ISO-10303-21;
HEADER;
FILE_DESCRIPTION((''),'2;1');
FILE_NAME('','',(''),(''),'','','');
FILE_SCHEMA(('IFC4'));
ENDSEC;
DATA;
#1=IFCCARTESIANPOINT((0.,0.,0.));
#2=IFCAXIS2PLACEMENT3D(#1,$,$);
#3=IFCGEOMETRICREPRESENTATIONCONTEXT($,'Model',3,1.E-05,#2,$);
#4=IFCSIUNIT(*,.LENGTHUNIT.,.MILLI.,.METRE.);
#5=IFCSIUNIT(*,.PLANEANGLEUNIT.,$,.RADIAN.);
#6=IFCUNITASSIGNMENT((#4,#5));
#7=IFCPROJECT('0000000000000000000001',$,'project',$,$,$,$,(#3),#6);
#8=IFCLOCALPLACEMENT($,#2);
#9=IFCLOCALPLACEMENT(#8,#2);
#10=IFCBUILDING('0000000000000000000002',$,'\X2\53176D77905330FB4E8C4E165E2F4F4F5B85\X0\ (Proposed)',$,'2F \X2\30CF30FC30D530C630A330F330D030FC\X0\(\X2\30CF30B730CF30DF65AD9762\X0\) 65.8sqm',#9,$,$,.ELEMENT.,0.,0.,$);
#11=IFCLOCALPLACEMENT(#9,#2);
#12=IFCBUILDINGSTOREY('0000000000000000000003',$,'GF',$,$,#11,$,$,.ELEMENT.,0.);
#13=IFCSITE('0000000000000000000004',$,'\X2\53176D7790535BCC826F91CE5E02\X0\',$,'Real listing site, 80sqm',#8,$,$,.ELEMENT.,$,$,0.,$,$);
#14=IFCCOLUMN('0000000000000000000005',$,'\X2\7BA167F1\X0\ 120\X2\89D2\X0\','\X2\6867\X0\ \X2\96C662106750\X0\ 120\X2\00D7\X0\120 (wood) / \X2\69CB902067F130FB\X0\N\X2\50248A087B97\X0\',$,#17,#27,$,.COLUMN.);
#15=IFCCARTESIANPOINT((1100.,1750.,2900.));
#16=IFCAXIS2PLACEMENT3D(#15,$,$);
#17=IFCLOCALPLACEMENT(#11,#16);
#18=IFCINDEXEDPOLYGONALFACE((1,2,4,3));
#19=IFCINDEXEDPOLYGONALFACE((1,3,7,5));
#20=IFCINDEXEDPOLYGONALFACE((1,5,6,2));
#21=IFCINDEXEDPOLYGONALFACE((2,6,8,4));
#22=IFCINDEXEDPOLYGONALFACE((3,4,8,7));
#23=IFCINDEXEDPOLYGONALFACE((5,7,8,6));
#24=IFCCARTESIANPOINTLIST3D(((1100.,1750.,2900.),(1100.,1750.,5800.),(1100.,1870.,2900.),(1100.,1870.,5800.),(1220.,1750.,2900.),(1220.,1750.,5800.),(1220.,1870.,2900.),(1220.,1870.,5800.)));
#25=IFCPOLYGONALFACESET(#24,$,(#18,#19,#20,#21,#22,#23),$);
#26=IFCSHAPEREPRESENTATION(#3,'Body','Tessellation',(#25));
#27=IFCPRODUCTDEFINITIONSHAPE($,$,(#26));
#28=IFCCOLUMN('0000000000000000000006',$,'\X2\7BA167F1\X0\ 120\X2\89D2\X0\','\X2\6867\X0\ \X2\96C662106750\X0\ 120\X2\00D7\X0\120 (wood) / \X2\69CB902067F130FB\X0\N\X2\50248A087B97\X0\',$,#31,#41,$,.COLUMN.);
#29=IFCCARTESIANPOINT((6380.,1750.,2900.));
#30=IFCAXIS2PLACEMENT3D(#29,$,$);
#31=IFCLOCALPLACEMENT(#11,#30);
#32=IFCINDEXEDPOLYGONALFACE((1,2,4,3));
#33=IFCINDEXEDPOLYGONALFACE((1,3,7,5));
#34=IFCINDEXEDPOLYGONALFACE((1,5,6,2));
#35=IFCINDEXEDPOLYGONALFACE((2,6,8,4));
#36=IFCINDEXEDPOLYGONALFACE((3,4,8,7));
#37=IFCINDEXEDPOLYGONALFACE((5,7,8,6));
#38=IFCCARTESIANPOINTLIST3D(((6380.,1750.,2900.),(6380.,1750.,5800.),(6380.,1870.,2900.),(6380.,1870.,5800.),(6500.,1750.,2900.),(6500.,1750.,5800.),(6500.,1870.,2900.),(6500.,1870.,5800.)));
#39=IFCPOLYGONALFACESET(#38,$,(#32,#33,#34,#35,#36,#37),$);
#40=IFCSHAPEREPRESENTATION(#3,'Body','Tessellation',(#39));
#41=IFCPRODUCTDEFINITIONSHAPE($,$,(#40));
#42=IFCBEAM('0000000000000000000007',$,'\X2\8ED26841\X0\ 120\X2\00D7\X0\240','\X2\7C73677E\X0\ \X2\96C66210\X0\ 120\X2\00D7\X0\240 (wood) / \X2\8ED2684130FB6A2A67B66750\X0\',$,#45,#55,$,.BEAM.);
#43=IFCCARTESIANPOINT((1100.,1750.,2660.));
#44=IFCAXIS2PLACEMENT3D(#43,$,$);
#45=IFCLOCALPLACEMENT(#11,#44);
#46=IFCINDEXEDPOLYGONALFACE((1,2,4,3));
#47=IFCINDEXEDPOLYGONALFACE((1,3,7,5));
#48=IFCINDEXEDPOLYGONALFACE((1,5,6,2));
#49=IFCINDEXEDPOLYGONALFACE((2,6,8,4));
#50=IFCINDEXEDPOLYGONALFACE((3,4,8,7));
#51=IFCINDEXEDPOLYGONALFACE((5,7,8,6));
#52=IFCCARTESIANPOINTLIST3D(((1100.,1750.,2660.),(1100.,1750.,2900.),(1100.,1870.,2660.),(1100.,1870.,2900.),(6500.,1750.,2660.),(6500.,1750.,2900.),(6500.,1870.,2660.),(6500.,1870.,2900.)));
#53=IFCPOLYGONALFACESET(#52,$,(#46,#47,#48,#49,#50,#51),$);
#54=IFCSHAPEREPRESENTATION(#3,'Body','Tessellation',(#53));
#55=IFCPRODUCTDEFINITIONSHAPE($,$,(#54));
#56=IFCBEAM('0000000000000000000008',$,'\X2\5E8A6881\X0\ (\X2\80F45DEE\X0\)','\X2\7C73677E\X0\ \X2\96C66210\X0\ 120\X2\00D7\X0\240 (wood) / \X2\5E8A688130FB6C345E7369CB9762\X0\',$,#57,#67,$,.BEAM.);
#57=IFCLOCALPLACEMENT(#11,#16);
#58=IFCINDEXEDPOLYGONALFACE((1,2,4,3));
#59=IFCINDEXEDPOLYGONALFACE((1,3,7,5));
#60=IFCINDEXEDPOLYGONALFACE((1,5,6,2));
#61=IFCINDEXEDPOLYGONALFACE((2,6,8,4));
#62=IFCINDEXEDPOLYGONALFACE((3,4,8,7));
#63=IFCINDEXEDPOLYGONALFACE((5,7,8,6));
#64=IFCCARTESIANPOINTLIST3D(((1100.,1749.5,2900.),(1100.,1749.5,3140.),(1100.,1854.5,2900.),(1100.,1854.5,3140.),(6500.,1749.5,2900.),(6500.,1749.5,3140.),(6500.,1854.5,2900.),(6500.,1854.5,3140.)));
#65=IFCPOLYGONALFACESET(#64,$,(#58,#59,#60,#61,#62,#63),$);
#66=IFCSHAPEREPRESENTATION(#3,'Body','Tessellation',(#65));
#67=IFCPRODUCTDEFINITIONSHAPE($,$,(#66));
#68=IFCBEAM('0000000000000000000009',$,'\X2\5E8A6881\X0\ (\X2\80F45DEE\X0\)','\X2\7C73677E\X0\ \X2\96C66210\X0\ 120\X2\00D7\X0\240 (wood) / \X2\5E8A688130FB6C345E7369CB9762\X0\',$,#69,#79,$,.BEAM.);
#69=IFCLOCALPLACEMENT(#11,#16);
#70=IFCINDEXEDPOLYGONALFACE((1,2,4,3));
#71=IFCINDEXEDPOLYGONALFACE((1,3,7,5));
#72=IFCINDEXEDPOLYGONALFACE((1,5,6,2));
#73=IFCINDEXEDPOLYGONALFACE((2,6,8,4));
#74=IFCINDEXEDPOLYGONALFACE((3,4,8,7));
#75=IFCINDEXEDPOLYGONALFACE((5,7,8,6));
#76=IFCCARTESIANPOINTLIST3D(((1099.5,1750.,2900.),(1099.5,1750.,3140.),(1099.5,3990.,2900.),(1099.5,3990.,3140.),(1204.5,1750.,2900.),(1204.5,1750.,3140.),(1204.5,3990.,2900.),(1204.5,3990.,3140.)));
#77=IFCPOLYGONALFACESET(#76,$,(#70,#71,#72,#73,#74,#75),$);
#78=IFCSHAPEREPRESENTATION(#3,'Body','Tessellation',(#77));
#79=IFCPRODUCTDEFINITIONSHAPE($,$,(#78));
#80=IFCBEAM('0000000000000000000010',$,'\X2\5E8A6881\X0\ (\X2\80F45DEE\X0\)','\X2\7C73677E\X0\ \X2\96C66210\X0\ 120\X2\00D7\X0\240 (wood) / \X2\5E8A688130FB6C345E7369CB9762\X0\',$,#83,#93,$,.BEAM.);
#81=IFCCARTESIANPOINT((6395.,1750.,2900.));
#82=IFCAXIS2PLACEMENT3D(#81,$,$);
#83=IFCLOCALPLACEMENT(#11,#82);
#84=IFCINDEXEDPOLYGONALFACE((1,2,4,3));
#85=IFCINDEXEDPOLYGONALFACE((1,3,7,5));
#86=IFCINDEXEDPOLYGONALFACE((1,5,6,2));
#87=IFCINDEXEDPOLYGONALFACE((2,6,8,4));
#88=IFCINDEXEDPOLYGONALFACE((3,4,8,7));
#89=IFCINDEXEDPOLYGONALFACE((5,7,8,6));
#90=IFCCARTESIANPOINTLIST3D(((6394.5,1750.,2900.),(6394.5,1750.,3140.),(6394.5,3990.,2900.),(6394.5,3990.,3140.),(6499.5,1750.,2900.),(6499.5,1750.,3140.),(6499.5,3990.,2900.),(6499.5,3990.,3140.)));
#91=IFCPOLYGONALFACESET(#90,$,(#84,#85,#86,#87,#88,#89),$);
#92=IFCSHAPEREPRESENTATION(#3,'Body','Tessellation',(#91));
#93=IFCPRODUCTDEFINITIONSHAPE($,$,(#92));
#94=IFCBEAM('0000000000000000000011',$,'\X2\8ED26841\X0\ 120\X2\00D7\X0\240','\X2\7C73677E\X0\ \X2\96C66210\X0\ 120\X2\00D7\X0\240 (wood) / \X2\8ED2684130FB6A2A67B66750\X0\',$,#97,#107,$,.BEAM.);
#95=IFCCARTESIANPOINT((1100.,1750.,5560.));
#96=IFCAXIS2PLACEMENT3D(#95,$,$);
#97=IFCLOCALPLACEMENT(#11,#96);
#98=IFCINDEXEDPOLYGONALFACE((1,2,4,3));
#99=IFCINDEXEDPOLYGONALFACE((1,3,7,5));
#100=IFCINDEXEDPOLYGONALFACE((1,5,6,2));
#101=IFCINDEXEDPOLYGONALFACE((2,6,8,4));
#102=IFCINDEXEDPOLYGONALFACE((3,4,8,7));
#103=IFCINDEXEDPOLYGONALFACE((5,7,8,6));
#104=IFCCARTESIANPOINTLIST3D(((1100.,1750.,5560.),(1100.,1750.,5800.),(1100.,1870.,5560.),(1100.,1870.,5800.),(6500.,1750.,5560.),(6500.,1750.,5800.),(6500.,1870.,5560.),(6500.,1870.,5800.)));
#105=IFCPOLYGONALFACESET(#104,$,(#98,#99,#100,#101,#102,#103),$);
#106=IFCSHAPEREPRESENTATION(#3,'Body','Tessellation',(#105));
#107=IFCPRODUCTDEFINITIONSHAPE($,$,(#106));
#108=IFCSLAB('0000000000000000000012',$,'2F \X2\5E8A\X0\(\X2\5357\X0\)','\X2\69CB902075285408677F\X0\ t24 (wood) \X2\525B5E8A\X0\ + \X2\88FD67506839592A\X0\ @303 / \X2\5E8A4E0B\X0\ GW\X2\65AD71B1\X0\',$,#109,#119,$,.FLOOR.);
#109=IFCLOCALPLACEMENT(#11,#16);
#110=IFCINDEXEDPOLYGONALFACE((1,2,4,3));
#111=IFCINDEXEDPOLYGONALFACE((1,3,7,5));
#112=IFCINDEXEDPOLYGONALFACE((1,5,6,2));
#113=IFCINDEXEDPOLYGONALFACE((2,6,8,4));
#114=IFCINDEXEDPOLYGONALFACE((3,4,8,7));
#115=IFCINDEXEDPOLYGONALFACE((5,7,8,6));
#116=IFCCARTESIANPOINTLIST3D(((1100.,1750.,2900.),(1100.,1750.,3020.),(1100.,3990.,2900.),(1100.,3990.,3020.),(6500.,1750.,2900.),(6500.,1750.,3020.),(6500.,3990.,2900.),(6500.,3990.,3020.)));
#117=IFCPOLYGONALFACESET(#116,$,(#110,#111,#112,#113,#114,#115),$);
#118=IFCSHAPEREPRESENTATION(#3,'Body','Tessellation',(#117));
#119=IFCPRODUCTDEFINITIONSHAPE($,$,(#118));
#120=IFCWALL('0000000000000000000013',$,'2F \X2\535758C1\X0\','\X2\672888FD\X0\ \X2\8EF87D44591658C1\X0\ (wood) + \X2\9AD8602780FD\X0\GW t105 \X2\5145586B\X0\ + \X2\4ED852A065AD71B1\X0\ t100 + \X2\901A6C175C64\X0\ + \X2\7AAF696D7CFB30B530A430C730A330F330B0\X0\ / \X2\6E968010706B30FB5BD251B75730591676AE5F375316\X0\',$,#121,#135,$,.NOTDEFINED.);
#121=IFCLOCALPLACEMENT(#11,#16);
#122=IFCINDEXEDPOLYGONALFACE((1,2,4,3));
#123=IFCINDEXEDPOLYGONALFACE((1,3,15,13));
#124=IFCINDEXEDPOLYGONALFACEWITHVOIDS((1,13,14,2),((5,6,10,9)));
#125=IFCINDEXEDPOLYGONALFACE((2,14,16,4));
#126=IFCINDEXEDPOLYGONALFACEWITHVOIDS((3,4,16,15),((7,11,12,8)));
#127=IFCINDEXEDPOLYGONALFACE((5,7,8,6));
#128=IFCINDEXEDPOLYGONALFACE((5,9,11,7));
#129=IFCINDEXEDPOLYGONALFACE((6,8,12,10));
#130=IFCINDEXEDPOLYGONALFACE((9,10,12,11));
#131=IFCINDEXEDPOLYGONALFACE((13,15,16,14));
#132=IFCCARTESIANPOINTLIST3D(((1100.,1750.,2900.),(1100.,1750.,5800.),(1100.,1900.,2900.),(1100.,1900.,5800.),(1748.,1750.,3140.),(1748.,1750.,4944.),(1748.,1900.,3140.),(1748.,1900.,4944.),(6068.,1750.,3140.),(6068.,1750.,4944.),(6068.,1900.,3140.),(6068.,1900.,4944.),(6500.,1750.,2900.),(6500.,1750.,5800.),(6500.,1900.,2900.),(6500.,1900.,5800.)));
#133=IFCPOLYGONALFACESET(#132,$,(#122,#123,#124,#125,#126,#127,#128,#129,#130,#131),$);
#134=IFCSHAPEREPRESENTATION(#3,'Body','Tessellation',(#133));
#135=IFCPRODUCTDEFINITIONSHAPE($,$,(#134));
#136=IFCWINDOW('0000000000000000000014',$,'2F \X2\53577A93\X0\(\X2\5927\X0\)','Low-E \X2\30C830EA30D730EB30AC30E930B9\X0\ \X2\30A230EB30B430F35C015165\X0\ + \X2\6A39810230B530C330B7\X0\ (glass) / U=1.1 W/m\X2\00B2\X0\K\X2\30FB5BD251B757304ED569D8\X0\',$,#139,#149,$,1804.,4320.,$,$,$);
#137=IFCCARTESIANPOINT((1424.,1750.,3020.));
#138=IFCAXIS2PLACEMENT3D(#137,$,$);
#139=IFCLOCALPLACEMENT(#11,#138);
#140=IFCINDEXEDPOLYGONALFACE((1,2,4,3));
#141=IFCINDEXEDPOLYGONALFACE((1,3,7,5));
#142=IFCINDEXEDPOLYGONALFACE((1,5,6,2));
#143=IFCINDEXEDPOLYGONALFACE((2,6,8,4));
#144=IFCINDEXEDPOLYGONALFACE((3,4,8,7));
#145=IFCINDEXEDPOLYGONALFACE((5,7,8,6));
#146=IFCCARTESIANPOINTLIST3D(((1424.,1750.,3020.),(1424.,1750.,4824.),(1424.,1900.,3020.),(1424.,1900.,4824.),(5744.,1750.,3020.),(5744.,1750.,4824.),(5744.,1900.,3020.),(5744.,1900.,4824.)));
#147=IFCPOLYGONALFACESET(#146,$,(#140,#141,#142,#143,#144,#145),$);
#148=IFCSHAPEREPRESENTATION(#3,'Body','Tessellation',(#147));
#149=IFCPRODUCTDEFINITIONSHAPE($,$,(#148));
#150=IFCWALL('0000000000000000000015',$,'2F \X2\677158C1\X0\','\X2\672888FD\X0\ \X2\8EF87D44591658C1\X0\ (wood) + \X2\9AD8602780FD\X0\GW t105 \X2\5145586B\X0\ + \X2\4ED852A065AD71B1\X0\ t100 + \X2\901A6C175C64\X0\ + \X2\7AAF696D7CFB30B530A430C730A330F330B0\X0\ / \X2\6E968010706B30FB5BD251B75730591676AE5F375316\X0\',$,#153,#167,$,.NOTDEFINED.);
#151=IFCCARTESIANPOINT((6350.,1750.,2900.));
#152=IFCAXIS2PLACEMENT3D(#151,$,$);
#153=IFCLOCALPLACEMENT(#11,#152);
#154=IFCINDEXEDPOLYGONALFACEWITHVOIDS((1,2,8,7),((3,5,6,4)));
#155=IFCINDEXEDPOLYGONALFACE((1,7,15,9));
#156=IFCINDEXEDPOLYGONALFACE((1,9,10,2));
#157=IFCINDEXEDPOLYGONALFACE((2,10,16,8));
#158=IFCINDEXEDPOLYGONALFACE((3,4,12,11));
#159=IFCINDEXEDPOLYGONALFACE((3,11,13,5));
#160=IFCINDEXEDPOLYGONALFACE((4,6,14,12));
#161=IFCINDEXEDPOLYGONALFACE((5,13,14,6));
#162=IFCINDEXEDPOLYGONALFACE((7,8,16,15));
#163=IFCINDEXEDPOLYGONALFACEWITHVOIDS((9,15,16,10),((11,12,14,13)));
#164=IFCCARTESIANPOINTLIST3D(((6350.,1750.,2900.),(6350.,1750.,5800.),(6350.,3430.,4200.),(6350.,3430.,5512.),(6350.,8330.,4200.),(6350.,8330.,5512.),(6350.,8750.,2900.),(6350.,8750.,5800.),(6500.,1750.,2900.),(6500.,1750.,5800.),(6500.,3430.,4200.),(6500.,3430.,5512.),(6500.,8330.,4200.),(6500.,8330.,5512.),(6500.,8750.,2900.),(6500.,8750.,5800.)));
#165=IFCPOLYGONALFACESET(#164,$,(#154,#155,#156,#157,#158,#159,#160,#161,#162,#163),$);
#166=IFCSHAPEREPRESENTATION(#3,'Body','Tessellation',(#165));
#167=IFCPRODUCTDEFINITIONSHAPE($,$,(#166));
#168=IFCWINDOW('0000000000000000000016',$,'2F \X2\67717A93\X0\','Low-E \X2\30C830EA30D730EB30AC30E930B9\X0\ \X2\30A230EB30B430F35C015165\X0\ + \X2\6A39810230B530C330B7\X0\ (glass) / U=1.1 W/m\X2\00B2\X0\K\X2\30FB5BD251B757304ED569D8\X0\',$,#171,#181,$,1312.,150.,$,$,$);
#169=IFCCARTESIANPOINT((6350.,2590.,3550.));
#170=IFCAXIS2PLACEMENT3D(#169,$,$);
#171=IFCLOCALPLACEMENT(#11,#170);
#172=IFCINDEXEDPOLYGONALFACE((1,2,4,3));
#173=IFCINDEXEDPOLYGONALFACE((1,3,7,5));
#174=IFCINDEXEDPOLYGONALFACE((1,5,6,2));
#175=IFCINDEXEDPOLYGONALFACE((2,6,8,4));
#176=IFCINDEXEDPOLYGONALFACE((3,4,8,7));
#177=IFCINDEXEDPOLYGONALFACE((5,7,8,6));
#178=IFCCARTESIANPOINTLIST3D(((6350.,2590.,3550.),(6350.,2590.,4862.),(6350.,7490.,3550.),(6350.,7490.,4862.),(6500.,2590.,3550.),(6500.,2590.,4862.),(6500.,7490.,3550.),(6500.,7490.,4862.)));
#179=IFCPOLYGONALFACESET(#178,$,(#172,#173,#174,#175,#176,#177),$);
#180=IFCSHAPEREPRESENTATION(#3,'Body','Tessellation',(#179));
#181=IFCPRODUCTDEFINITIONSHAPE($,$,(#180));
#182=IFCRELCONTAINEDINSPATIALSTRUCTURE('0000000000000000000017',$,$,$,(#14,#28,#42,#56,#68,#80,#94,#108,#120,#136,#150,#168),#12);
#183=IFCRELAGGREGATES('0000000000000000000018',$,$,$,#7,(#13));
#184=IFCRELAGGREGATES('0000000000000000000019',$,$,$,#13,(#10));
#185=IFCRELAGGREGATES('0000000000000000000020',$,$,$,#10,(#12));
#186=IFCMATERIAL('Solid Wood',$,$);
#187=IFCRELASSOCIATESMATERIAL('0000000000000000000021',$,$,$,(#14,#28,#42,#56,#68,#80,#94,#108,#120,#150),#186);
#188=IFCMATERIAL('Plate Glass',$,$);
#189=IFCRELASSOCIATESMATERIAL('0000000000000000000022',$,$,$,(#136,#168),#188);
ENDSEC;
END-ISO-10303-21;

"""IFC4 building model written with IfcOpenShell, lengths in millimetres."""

from ifc_helpers import new_model, si_unit, frame, frame_2d, origin, place, context, project, spatial, rectangle, extrude, material, element, fill, save


model = new_model("IFC4")

# Units and contexts
model_context = context("Model", 3, precision=1e-05, world=origin())
ifc_project = project(units=[si_unit("LENGTHUNIT", "METRE", prefix="MILLI"), si_unit("PLANEANGLEUNIT", "RADIAN")], contexts=[model_context])

# Site, building, storey
site_placement = place(None, origin())
site = spatial("IfcSite", under=ifc_project, at=site_placement, Name="北海道富良野市", ObjectType="Real listing site, 80sqm", CompositionType="ELEMENT", RefElevation=0.0)
building_placement = place(site_placement, origin())
building = spatial("IfcBuilding", under=site, at=building_placement, Name="北海道・二世帯住宅 (Proposed)", ObjectType="2F ハーフティンバー(ハシハミ断面) 65.8sqm", CompositionType="ELEMENT", ElevationOfRefHeight=0.0, ElevationOfTerrain=0.0)
storey_placement = place(building_placement, origin())
storey = spatial("IfcBuildingStorey", under=building, at=storey_placement, Name="GF", CompositionType="ELEMENT", Elevation=0.0)

# Columns
ifc_material_1 = material(Name="Solid Wood")
column_1_placement = place(storey_placement, frame((1100.0, 1750.0, 2900.0)))
element("IfcColumn", 1, at=column_1_placement, inside=storey, material=ifc_material_1, Name="管柱 120角", Description="桧 集成材 120×120 (wood) / 構造柱・N値計算", PredefinedType="COLUMN", context=model_context, shape_type="SweptSolid", body=[
    extrude(rectangle(XDim=120.0, YDim=120.0, at=frame_2d((60.0, 60.0))), frame((1100.0, 1750.0, 2900.0)), (0.0, 0.0, 1.0), 2900.0),
])
column_2_placement = place(storey_placement, frame((6380.0, 1750.0, 2900.0)))
element("IfcColumn", 2, at=column_2_placement, inside=storey, material=ifc_material_1, Name="管柱 120角", Description="桧 集成材 120×120 (wood) / 構造柱・N値計算", PredefinedType="COLUMN", context=model_context, shape_type="SweptSolid", body=[
    extrude(rectangle(XDim=120.0, YDim=120.0, at=frame_2d((60.0, 60.0))), frame((6380.0, 1750.0, 2900.0)), (0.0, 0.0, 1.0), 2900.0),
])

# Beams
beam_1_placement = place(storey_placement, frame((1100.0, 1750.0, 2660.0)))
element("IfcBeam", 3, at=beam_1_placement, inside=storey, material=ifc_material_1, Name="軒桁 120×240", Description="米松 集成 120×240 (wood) / 軒桁・横架材", PredefinedType="BEAM", context=model_context, shape_type="SweptSolid", body=[
    extrude(rectangle(XDim=5400.0, YDim=120.0, at=frame_2d((2700.0, 60.0))), frame((1100.0, 1750.0, 2660.0)), (0.0, 0.0, 1.0), 240.0),
])
beam_2_placement = place(storey_placement, frame((1100.0, 1750.0, 2900.0)))
element("IfcBeam", 4, at=beam_2_placement, inside=storey, material=ifc_material_1, Name="床梁 (胴差)", Description="米松 集成 120×240 (wood) / 床梁・水平構面", PredefinedType="BEAM", context=model_context, shape_type="SweptSolid", body=[
    extrude(rectangle(XDim=5400.0, YDim=105.0, at=frame_2d((2700.0, 52.0))), frame((1100.0, 1750.0, 2900.0)), (0.0, 0.0, 1.0), 240.0),
])
beam_3_placement = place(storey_placement, frame((1100.0, 1750.0, 2900.0)))
element("IfcBeam", 5, at=beam_3_placement, inside=storey, material=ifc_material_1, Name="床梁 (胴差)", Description="米松 集成 120×240 (wood) / 床梁・水平構面", PredefinedType="BEAM", context=model_context, shape_type="SweptSolid", body=[
    extrude(rectangle(XDim=105.0, YDim=2240.0, at=frame_2d((52.0, 1120.0))), frame((1100.0, 1750.0, 2900.0)), (0.0, 0.0, 1.0), 240.0),
])
beam_4_placement = place(storey_placement, frame((6395.0, 1750.0, 2900.0)))
element("IfcBeam", 6, at=beam_4_placement, inside=storey, material=ifc_material_1, Name="床梁 (胴差)", Description="米松 集成 120×240 (wood) / 床梁・水平構面", PredefinedType="BEAM", context=model_context, shape_type="SweptSolid", body=[
    extrude(rectangle(XDim=105.0, YDim=2240.0, at=frame_2d((52.0, 1120.0))), frame((6395.0, 1750.0, 2900.0)), (0.0, 0.0, 1.0), 240.0),
])
beam_5_placement = place(storey_placement, frame((1100.0, 1750.0, 5560.0)))
element("IfcBeam", 7, at=beam_5_placement, inside=storey, material=ifc_material_1, Name="軒桁 120×240", Description="米松 集成 120×240 (wood) / 軒桁・横架材", PredefinedType="BEAM", context=model_context, shape_type="SweptSolid", body=[
    extrude(rectangle(XDim=5400.0, YDim=120.0, at=frame_2d((2700.0, 60.0))), frame((1100.0, 1750.0, 5560.0)), (0.0, 0.0, 1.0), 240.0),
])

# Slab
slab_placement = place(storey_placement, frame((1100.0, 1750.0, 2900.0)))
element("IfcSlab", 8, at=slab_placement, inside=storey, material=ifc_material_1, Name="2F 床(南)", Description="構造用合板 t24 (wood) 剛床 + 製材根太 @303 / 床下 GW断熱", PredefinedType="FLOOR", context=model_context, shape_type="SweptSolid", body=[
    extrude(rectangle(XDim=5400.0, YDim=2240.0, at=frame_2d((2700.0, 1120.0))), frame((1100.0, 1750.0, 2900.0)), (0.0, 0.0, 1.0), 120.0),
])

# Walls, openings, windows
wall_1_placement = place(storey_placement, frame((1100.0, 1750.0, 2900.0)))
wall_1 = element("IfcWall", 9, at=wall_1_placement, inside=storey, material=ifc_material_1, Name="2F 南壁", Description="木製 軸組外壁 (wood) + 高性能GW t105 充填 + 付加断熱 t100 + 通気層 + 窯業系サイディング / 準耐火・寒冷地外皮強化", PredefinedType="NOTDEFINED", context=model_context, shape_type="SweptSolid", body=[
    extrude(rectangle(XDim=5400.0, YDim=150.0, at=frame_2d((2700.0, 75.0))), frame((1100.0, 1750.0, 2900.0)), (0.0, 0.0, 1.0), 2900.0),
])
opening_1_placement = place(storey_placement, frame((1424.0, 1750.0, 3020.0)))
opening_1 = element("IfcOpeningElement", 10, at=opening_1_placement, cuts=wall_1, PredefinedType="NOTDEFINED", context=model_context, shape_type="SweptSolid", body=[
    extrude(rectangle(XDim=4320.0, YDim=150.0, at=frame_2d((2160.0, 75.0))), frame((1424.0, 1750.0, 3020.0)), (0.0, 0.0, 1.0), 1804.0),
])
ifc_material_2 = material(Name="Plate Glass")
window_1_placement = place(storey_placement, frame((1424.0, 1750.0, 3020.0)))
window_1 = element("IfcWindow", 11, at=window_1_placement, inside=storey, material=ifc_material_2, Name="2F 南窓(大)", Description="Low-E トリプルガラス アルゴン封入 + 樹脂サッシ (glass) / U=1.1 W/m²K・寒冷地仕様", OverallHeight=1804.0, OverallWidth=4320.0, context=model_context, shape_type="SweptSolid", body=[
    extrude(rectangle(XDim=4320.0, YDim=150.0, at=frame_2d((2160.0, 75.0))), frame((1424.0, 1750.0, 3020.0)), (0.0, 0.0, 1.0), 1804.0),
])
fill(opening_1, window_1)
wall_2_placement = place(storey_placement, frame((6350.0, 1750.0, 2900.0)))
wall_2 = element("IfcWall", 12, at=wall_2_placement, inside=storey, material=ifc_material_1, Name="2F 東壁", Description="木製 軸組外壁 (wood) + 高性能GW t105 充填 + 付加断熱 t100 + 通気層 + 窯業系サイディング / 準耐火・寒冷地外皮強化", PredefinedType="NOTDEFINED", context=model_context, shape_type="SweptSolid", body=[
    extrude(rectangle(XDim=150.0, YDim=7000.0, at=frame_2d((75.0, 3500.0))), frame((6350.0, 1750.0, 2900.0)), (0.0, 0.0, 1.0), 2900.0),
])
opening_2_placement = place(storey_placement, frame((6350.0, 2590.0, 3550.0)))
opening_2 = element("IfcOpeningElement", 13, at=opening_2_placement, cuts=wall_2, PredefinedType="NOTDEFINED", context=model_context, shape_type="SweptSolid", body=[
    extrude(rectangle(XDim=150.0, YDim=4900.0, at=frame_2d((75.0, 2450.0))), frame((6350.0, 2590.0, 3550.0)), (0.0, 0.0, 1.0), 1312.0),
])
window_2_placement = place(storey_placement, frame((6350.0, 2590.0, 3550.0)))
window_2 = element("IfcWindow", 14, at=window_2_placement, inside=storey, material=ifc_material_2, Name="2F 東窓", Description="Low-E トリプルガラス アルゴン封入 + 樹脂サッシ (glass) / U=1.1 W/m²K・寒冷地仕様", OverallHeight=1312.0, OverallWidth=150.0, context=model_context, shape_type="SweptSolid", body=[
    extrude(rectangle(XDim=150.0, YDim=4900.0, at=frame_2d((75.0, 2450.0))), frame((6350.0, 2590.0, 3550.0)), (0.0, 0.0, 1.0), 1312.0),
])
fill(opening_2, window_2)

save(model, "model.ifc")
